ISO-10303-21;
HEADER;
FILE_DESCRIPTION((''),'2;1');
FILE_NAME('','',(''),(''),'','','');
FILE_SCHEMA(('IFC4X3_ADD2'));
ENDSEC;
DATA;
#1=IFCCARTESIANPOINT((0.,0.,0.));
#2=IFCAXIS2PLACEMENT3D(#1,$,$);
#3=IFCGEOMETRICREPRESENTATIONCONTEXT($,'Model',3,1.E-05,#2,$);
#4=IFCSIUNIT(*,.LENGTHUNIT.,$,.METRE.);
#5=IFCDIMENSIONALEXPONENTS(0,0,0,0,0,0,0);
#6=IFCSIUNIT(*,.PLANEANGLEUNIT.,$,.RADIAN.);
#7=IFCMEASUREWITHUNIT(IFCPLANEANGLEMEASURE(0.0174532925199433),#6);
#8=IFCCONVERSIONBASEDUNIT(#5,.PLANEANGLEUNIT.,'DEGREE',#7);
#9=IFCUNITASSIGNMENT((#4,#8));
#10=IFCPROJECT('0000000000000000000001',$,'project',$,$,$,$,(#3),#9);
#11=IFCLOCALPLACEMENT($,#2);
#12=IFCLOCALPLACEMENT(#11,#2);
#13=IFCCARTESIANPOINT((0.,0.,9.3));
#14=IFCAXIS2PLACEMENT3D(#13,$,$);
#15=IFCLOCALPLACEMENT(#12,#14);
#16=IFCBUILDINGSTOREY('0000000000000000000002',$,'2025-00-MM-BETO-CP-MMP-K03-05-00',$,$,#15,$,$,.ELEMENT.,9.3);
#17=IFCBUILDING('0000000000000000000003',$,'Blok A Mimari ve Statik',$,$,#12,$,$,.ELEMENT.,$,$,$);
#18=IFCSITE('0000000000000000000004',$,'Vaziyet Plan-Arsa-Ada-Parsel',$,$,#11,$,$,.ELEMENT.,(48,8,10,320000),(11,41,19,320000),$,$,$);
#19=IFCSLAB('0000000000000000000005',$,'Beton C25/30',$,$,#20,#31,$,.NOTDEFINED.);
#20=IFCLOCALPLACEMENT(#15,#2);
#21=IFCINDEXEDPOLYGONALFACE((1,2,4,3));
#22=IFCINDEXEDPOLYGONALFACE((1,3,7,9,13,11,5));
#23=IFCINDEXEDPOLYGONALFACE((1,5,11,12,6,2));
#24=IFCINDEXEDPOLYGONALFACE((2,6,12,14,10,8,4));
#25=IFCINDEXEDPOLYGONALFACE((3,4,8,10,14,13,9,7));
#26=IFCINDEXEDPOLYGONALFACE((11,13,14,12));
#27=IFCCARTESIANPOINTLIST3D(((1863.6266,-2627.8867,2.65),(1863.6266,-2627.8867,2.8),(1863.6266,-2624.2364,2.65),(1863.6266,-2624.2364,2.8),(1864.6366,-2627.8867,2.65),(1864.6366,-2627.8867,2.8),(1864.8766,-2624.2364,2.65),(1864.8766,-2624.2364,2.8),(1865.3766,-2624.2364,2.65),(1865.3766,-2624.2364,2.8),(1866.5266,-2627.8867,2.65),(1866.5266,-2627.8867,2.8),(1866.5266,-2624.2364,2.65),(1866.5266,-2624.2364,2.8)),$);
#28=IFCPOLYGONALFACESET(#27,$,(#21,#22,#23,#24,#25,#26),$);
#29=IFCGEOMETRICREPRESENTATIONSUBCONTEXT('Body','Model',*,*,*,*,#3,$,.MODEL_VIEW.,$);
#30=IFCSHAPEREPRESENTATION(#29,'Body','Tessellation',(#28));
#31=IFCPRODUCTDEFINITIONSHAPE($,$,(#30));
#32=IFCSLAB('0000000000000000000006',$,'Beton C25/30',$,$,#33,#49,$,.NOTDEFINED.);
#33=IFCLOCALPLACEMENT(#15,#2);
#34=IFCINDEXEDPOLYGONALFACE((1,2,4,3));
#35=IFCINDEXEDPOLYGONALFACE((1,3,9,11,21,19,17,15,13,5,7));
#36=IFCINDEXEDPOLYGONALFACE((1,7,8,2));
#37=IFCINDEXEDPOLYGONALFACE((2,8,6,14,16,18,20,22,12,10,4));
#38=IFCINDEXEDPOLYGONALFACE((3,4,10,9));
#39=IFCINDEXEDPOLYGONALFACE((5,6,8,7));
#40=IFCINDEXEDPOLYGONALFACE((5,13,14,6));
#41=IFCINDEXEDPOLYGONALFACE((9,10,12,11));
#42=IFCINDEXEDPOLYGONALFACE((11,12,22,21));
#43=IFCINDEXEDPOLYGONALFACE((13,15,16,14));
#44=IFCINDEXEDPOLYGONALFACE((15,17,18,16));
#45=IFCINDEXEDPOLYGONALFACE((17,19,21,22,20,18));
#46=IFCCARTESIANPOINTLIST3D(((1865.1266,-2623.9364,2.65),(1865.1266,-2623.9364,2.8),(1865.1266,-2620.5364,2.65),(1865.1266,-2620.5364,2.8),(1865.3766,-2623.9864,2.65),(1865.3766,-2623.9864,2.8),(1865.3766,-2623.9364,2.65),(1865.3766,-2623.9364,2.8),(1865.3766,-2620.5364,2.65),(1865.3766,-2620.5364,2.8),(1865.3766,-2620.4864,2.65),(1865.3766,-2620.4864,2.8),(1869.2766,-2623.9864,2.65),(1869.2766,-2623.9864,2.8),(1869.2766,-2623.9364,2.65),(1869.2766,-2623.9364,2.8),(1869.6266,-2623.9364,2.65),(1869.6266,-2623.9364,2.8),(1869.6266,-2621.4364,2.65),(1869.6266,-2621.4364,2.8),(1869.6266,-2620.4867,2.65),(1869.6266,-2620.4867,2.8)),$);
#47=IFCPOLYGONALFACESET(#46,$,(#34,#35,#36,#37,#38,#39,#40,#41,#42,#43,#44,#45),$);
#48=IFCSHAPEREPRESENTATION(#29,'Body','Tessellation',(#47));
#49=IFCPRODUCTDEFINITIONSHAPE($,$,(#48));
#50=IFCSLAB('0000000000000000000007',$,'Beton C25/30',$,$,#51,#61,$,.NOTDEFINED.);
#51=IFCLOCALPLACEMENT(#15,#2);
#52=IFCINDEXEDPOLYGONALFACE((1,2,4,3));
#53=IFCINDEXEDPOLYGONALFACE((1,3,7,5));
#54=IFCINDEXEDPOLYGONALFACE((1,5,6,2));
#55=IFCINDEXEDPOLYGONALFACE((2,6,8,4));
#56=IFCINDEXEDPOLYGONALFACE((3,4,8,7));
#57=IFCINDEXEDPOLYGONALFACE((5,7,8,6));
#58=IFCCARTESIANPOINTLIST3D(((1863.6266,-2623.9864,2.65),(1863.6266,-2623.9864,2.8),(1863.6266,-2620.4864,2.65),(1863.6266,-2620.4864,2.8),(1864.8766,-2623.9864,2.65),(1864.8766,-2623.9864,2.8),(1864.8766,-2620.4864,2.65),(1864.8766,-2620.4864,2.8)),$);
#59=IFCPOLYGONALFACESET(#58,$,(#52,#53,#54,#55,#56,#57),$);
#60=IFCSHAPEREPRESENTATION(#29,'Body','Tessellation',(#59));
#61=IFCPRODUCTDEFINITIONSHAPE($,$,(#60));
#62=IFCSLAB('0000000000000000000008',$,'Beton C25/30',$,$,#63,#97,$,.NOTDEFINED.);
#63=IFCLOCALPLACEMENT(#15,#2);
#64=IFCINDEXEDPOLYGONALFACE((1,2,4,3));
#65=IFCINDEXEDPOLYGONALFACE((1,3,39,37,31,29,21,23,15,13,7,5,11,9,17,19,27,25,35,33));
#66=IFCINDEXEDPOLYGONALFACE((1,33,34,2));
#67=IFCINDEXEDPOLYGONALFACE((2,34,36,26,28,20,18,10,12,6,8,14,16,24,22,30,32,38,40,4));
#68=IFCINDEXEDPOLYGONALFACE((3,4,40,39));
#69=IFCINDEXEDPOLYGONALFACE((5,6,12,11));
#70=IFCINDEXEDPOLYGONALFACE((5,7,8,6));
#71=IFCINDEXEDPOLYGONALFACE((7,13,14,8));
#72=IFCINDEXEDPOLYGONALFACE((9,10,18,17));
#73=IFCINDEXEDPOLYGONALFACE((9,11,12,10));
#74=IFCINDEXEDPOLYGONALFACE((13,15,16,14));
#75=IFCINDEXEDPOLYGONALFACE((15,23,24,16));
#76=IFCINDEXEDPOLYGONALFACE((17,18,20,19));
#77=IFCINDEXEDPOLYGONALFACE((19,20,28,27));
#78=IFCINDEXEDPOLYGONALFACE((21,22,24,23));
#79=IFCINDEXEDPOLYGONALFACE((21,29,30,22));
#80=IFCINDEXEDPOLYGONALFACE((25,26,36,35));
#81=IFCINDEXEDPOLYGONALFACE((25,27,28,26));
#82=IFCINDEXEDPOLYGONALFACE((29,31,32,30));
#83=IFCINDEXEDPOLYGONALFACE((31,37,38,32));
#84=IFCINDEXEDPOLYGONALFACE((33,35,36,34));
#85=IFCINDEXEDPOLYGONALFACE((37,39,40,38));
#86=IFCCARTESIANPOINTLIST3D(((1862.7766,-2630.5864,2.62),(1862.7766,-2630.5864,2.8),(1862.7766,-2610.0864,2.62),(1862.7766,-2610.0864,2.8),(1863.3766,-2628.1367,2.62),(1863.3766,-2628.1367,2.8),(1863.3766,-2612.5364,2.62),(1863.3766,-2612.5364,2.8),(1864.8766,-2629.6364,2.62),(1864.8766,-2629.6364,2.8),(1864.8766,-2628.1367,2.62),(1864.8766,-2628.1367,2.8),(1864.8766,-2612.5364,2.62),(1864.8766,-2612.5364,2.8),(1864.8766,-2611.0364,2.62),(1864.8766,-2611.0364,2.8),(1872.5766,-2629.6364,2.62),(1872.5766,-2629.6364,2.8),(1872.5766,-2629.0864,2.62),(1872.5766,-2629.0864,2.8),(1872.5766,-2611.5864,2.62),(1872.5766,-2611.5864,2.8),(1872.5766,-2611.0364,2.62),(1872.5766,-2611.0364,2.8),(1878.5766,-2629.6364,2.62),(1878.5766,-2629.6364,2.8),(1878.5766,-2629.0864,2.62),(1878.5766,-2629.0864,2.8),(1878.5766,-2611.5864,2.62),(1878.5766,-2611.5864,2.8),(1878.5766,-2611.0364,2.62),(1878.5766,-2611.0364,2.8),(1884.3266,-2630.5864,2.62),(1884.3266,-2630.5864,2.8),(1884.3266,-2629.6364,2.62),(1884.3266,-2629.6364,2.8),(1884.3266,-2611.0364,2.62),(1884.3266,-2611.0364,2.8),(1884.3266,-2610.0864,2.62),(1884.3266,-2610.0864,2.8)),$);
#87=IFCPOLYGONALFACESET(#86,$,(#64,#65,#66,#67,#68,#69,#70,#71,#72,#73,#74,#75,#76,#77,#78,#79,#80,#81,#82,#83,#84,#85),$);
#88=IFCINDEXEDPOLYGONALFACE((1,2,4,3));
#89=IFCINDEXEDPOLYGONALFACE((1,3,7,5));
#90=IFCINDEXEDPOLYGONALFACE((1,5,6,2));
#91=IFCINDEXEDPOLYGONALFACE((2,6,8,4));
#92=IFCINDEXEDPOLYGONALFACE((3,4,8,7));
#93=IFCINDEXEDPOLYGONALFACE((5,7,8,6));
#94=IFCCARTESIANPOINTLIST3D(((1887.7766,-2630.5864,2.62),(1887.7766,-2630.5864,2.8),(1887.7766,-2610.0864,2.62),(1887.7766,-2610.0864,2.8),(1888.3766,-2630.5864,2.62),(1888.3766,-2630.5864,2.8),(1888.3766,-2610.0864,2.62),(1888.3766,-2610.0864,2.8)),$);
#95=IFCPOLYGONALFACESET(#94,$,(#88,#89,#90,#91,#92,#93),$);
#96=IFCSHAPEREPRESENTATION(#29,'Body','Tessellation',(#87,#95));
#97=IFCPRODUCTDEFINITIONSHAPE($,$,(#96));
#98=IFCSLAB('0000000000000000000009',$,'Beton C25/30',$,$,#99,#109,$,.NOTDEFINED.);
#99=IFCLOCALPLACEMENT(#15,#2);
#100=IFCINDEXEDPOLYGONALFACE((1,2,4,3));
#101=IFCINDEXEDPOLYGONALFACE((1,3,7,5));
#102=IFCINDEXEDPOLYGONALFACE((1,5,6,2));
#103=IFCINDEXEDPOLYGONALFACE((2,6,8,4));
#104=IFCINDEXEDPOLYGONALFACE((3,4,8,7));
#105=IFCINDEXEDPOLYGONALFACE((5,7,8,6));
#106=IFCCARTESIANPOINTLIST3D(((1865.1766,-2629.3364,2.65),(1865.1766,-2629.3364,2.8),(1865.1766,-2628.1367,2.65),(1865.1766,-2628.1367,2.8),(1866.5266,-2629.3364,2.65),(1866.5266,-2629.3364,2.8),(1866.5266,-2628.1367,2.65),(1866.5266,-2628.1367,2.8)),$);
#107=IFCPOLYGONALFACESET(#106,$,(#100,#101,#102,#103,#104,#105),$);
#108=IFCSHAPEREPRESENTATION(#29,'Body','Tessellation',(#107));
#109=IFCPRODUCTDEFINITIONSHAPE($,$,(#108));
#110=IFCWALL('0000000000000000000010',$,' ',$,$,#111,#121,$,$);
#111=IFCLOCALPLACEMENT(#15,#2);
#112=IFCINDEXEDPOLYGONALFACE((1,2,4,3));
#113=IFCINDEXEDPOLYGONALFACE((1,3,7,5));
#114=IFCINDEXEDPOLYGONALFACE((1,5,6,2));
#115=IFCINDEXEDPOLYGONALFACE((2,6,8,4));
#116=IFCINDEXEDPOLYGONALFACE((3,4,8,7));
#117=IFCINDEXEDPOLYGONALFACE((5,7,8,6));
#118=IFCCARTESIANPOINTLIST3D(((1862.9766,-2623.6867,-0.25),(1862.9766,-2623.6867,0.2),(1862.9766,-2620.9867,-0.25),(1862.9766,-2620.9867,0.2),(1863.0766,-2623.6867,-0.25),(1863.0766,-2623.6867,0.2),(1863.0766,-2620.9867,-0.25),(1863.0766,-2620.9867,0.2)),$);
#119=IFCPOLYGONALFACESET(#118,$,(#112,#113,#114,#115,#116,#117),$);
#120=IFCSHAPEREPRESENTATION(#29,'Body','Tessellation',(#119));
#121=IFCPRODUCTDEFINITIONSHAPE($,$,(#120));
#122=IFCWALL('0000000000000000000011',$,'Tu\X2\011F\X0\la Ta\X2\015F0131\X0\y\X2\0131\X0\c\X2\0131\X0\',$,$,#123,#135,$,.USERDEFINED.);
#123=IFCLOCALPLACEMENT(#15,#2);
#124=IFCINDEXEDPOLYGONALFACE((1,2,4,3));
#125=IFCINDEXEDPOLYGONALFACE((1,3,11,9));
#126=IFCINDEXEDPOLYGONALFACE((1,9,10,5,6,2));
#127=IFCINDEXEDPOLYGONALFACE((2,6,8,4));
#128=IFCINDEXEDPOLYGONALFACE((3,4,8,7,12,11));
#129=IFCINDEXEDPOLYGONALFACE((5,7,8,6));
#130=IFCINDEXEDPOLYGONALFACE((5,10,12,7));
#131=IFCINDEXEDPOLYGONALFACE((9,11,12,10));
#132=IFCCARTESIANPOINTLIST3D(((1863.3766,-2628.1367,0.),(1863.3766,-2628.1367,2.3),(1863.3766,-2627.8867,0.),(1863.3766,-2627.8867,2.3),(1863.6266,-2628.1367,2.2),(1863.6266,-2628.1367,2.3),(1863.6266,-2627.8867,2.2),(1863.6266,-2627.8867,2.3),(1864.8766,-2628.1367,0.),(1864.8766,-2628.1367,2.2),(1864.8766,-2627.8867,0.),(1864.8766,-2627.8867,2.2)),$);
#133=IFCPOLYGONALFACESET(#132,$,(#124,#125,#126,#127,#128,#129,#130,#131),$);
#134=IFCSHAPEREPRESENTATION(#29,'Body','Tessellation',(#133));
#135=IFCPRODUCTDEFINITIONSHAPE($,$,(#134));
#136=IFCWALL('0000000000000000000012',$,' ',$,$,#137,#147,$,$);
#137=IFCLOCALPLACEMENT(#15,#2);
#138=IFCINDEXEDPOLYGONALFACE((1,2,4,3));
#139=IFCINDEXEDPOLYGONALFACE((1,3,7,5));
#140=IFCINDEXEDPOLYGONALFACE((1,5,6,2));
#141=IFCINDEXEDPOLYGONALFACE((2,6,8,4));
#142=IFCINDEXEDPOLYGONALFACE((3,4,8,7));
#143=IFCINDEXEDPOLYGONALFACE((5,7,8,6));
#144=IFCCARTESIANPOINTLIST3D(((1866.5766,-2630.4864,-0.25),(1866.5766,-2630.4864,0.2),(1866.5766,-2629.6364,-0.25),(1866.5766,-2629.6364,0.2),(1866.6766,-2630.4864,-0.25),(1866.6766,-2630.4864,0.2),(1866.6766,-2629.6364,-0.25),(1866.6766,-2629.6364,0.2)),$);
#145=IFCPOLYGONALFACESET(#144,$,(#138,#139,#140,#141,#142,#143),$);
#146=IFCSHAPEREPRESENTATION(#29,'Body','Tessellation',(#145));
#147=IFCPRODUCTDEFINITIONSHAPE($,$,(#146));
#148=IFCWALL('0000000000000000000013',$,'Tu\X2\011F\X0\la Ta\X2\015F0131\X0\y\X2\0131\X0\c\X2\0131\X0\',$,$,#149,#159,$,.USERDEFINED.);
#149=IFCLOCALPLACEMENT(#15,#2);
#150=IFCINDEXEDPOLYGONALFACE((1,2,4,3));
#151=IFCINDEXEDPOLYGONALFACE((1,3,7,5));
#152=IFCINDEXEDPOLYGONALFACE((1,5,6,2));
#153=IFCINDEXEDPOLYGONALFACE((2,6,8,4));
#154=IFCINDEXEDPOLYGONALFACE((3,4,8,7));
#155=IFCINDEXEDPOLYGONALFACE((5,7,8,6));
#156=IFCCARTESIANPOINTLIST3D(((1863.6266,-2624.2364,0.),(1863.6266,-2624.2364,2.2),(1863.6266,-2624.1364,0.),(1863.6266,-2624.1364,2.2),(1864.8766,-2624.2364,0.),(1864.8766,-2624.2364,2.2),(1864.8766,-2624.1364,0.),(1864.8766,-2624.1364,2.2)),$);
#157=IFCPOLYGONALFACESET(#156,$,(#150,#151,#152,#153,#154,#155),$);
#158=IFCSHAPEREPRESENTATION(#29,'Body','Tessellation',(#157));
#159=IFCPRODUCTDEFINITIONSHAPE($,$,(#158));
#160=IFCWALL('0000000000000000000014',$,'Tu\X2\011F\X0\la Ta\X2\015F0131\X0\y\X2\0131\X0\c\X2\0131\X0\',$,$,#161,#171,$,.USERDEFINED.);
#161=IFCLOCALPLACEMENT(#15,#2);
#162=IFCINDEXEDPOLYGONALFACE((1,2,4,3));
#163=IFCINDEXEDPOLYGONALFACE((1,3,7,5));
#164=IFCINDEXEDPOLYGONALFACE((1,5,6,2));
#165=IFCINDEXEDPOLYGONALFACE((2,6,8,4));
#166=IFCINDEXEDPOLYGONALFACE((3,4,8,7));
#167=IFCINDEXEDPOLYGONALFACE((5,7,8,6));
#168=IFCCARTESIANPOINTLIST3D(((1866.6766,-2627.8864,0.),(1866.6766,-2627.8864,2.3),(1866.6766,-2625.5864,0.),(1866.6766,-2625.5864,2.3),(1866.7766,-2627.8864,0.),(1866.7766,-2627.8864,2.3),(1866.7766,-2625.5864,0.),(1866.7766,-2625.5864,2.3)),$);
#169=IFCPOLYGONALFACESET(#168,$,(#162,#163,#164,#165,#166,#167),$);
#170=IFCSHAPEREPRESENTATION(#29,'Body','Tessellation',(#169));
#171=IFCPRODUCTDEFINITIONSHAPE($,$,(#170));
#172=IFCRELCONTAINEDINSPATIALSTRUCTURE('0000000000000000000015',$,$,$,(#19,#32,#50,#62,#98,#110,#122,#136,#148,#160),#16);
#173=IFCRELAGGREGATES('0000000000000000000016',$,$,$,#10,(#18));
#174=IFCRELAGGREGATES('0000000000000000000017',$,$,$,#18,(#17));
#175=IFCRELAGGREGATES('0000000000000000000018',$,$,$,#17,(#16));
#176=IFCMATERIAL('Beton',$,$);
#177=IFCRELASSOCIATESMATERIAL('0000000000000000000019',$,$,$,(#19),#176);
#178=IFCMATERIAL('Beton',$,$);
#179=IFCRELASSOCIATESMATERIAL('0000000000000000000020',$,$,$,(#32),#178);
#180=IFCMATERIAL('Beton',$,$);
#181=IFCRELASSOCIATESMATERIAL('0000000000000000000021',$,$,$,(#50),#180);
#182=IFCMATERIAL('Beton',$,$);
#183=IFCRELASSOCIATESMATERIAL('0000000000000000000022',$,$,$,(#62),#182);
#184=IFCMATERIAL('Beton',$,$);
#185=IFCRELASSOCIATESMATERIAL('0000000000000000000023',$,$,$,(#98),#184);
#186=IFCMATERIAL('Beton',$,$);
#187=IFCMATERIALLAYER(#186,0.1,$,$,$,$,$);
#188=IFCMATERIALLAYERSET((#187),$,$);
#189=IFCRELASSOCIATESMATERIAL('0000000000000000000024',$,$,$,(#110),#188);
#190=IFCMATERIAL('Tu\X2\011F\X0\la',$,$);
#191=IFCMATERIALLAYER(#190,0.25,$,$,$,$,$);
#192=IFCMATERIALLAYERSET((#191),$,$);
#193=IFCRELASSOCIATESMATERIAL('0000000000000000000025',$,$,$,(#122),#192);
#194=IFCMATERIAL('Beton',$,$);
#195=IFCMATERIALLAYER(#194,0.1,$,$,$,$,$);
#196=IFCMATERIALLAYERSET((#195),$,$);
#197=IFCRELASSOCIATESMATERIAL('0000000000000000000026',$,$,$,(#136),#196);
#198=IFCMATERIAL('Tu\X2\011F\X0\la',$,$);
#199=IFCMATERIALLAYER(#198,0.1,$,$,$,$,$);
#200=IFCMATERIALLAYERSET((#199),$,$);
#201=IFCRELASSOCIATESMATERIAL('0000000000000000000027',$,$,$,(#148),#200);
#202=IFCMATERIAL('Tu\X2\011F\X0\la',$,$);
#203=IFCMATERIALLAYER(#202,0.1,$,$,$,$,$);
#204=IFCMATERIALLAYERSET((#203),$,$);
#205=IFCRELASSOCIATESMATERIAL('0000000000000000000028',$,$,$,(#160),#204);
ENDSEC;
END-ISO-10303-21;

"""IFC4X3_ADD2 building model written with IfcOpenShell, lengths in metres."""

from ifc_helpers import new_model, entity, si_unit, converted_unit, frame, frame_2d, origin, origin_with_axes, place, context, subcontext, project, spatial, polyline, rectangle, outline, extrude, clip, bounded_halfspace, material, layer, layer_set, layer_usage, element, save


model = new_model("IFC4X3_ADD2")

# Units and contexts
model_context = context("Model", 3, precision=1e-05, world=origin())
body_context = subcontext(model_context, "Body", "Model", "MODEL_VIEW")
ifc_project = project(units=[si_unit("LENGTHUNIT", "METRE"), converted_unit("PLANEANGLEUNIT", "DEGREE", entity("IfcPlaneAngleMeasure", 0.0174532925199433), si_unit("PLANEANGLEUNIT", "RADIAN"), dimensions=[0, 0, 0, 0, 0, 0, 0])], contexts=[model_context])

# Site, building, storey
site_placement = place(None, origin())
site = spatial("IfcSite", under=ifc_project, at=site_placement, Name="Vaziyet Plan-Arsa-Ada-Parsel", CompositionType="ELEMENT", RefLatitude=(48, 8, 10, 320000), RefLongitude=(11, 41, 19, 320000))
building_placement = place(site_placement, origin())
building = spatial("IfcBuilding", under=site, at=building_placement, Name="Blok A Mimari ve Statik", CompositionType="ELEMENT")
storey_placement = place(building_placement, frame((0.0, 0.0, 9.3)))
storey = spatial("IfcBuildingStorey", under=building, at=storey_placement, Name="2025-00-MM-BETO-CP-MMP-K03-05-00", CompositionType="ELEMENT", Elevation=9.3)

# Slabs
ifc_material_1 = material(Name="Beton")
slab_1_placement = place(storey_placement, frame((1863.6266, -2627.8867, 2.65)))
element("IfcSlab", 1, at=slab_1_placement, inside=storey, material=ifc_material_1, Name="Beton C25/30", PredefinedType="NOTDEFINED", context=body_context, shape_type="SweptSolid", body=[
    extrude(outline(polyline([(1.25, 3.6503), (0.0, 3.6503), (0.0, 0.0), (1.01, 0.0), (2.9, 0.0), (2.9, 3.6503), (1.75, 3.6503), (1.25, 3.6503)])), origin_with_axes(), (0.0, 0.0, 1.0), 0.15),
])
ifc_material_2 = material(Name="Beton")
slab_2_placement = place(storey_placement, frame((1865.1266, -2623.9864, 2.65)))
element("IfcSlab", 2, at=slab_2_placement, inside=storey, material=ifc_material_2, Name="Beton C25/30", PredefinedType="NOTDEFINED", context=body_context, shape_type="SweptSolid", body=[
    extrude(outline(polyline([(0.25, 3.5), (0.25, 3.45), (0.0, 3.45), (0.0, 0.05), (0.25, 0.05), (0.25, 0.0), (4.15, 0.0), (4.15, 0.05), (4.5, 0.05), (4.5, 2.55), (4.5, 3.4997), (0.25, 3.5)])), origin_with_axes(), (0.0, 0.0, 1.0), 0.15),
])
ifc_material_3 = material(Name="Beton")
slab_3_placement = place(storey_placement, frame((1863.6266, -2623.9864, 2.65)))
element("IfcSlab", 3, at=slab_3_placement, inside=storey, material=ifc_material_3, Name="Beton C25/30", PredefinedType="NOTDEFINED", context=body_context, shape_type="SweptSolid", body=[
    extrude(rectangle(XDim=3.5, YDim=1.25, at=frame_2d((0.625, -1.75), x_axis=(0.0, -1.0))), frame((0.0, 3.5, 0.0), z_axis=(0.0, 0.0, 1.0), x_axis=(1.0, 0.0, 0.0)), (0.0, 0.0, 1.0), 0.15),
])
ifc_material_4 = material(Name="Beton")
slab_4_placement = place(storey_placement, frame((1862.7766, -2630.5864, 2.62)))
element("IfcSlab", 4, at=slab_4_placement, inside=storey, material=ifc_material_4, Name="Beton C25/30", PredefinedType="NOTDEFINED", context=body_context, shape_type="SweptSolid", body=[
    extrude(outline(polyline([(0.0, 0.0), (21.55, 0.0), (21.55, 0.95), (15.8, 0.95), (15.8, 1.5), (9.8, 1.5), (9.8, 0.95), (2.1, 0.95), (2.1, 2.4497), (0.6, 2.4497), (0.6, 18.05), (2.1, 18.05), (2.1, 19.55), (9.8, 19.55), (9.8, 19.0), (15.8, 19.0), (15.8, 19.55), (21.55, 19.55), (21.55, 20.5), (0.0, 20.5), (0.0, 0.0)])), origin_with_axes(), (0.0, 0.0, 1.0), 0.18),
    extrude(rectangle(XDim=0.6, YDim=20.5, at=frame_2d((0.3, 10.25), x_axis=(1.0, 0.0))), frame((25.0, 0.0, 0.0), z_axis=(0.0, 0.0, 1.0), x_axis=(1.0, 0.0, 0.0)), (0.0, 0.0, 1.0), 0.18),
])
ifc_material_5 = material(Name="Beton")
slab_5_placement = place(storey_placement, frame((1865.1766, -2629.3364, 2.65)))
element("IfcSlab", 5, at=slab_5_placement, inside=storey, material=ifc_material_5, Name="Beton C25/30", PredefinedType="NOTDEFINED", context=body_context, shape_type="SweptSolid", body=[
    extrude(rectangle(XDim=1.35, YDim=1.1997, at=frame_2d((0.675, 0.5998), x_axis=(1.0, 0.0))), origin_with_axes(), (0.0, 0.0, 1.0), 0.15),
])

# Walls
ifc_material_6 = material(Name="Beton")
ifc_layer_1 = layer(ifc_material_6, 0.1)
ifc_layer_set_1 = layer_set([ifc_layer_1])
ifc_layer_usage_1 = layer_usage(ifc_layer_set_1, "AXIS2", "POSITIVE", 0.0)
wall_1_placement = place(storey_placement, frame((1862.9766, -2620.9867, -0.25), z_axis=(0.0, 0.0, 1.0), x_axis=(0.0, -1.0, 0.0)))
element("IfcWall", 6, at=wall_1_placement, inside=storey, material=ifc_layer_usage_1, Name=" ", context=body_context, shape_type="SweptSolid", body=[
    extrude(rectangle(XDim=2.7, YDim=0.1, at=frame_2d((1.35, 0.05), x_axis=(1.0, 0.0))), origin_with_axes(), (0.0, 0.0, 1.0), 0.45),
])
ifc_material_7 = material(Name="Tuğla")
ifc_layer_2 = layer(ifc_material_7, 0.25)
ifc_layer_set_2 = layer_set([ifc_layer_2])
ifc_layer_usage_2 = layer_usage(ifc_layer_set_2, "AXIS2", "POSITIVE", 0.0)
wall_2_placement = place(storey_placement, frame((1863.3766, -2628.1367, 0.0)))
element("IfcWall", 7, at=wall_2_placement, inside=storey, material=ifc_layer_usage_2, Name="Tuğla Taşıyıcı", PredefinedType="USERDEFINED", context=body_context, shape_type="Clipping", body=[
    clip(extrude(rectangle(XDim=1.5, YDim=0.25, at=frame_2d((0.75, 0.125), x_axis=(1.0, 0.0))), origin_with_axes(), (0.0, 0.0, 1.0), 2.3), bounded_halfspace(frame((0.875, 0.125, 2.2), z_axis=(0.0, 0.0, -1.0), x_axis=(0.0, -1.0, 0.0)), True, origin_with_axes(), polyline([(0.25, 0.25), (0.25, 0.0), (1.5, 0.0), (1.5, 0.25), (0.25, 0.25)]))),
])
ifc_material_8 = material(Name="Beton")
ifc_layer_3 = layer(ifc_material_8, 0.1)
ifc_layer_set_3 = layer_set([ifc_layer_3])
ifc_layer_usage_3 = layer_usage(ifc_layer_set_3, "AXIS2", "POSITIVE", 0.0)
wall_3_placement = place(storey_placement, frame((1866.6766, -2630.4864, -0.25), z_axis=(0.0, 0.0, 1.0), x_axis=(0.0, 1.0, 0.0)))
element("IfcWall", 8, at=wall_3_placement, inside=storey, material=ifc_layer_usage_3, Name=" ", context=body_context, shape_type="SweptSolid", body=[
    extrude(rectangle(XDim=0.85, YDim=0.1, at=frame_2d((0.425, 0.05), x_axis=(1.0, 0.0))), origin_with_axes(), (0.0, 0.0, 1.0), 0.45),
])
ifc_material_9 = material(Name="Tuğla")
ifc_layer_4 = layer(ifc_material_9, 0.1)
ifc_layer_set_4 = layer_set([ifc_layer_4])
ifc_layer_usage_4 = layer_usage(ifc_layer_set_4, "AXIS2", "POSITIVE", 0.0)
wall_4_placement = place(storey_placement, frame((1863.6266, -2624.2364, 0.0), z_axis=(0.0, 0.0, 1.0), x_axis=(1.0, 0.000002, 0.0)))
element("IfcWall", 9, at=wall_4_placement, inside=storey, material=ifc_layer_usage_4, Name="Tuğla Taşıyıcı", PredefinedType="USERDEFINED", context=body_context, shape_type="SweptSolid", body=[
    extrude(rectangle(XDim=1.25, YDim=0.1, at=frame_2d((0.625, 0.05), x_axis=(1.0, 0.0))), origin_with_axes(), (0.0, 0.0, 1.0), 2.2),
])
ifc_material_10 = material(Name="Tuğla")
ifc_layer_5 = layer(ifc_material_10, 0.1)
ifc_layer_set_5 = layer_set([ifc_layer_5])
ifc_layer_usage_5 = layer_usage(ifc_layer_set_5, "AXIS2", "POSITIVE", 0.0)
wall_5_placement = place(storey_placement, frame((1866.6766, -2625.5864, 0.0), z_axis=(0.0, 0.0, 1.0), x_axis=(0.0, -1.0, 0.0)))
element("IfcWall", 10, at=wall_5_placement, inside=storey, material=ifc_layer_usage_5, Name="Tuğla Taşıyıcı", PredefinedType="USERDEFINED", context=body_context, shape_type="SweptSolid", body=[
    extrude(rectangle(XDim=2.3, YDim=0.1, at=frame_2d((1.15, 0.05), x_axis=(1.0, 0.0))), origin_with_axes(), (0.0, 0.0, 1.0), 2.3),
])

save(model, "model.ifc")
